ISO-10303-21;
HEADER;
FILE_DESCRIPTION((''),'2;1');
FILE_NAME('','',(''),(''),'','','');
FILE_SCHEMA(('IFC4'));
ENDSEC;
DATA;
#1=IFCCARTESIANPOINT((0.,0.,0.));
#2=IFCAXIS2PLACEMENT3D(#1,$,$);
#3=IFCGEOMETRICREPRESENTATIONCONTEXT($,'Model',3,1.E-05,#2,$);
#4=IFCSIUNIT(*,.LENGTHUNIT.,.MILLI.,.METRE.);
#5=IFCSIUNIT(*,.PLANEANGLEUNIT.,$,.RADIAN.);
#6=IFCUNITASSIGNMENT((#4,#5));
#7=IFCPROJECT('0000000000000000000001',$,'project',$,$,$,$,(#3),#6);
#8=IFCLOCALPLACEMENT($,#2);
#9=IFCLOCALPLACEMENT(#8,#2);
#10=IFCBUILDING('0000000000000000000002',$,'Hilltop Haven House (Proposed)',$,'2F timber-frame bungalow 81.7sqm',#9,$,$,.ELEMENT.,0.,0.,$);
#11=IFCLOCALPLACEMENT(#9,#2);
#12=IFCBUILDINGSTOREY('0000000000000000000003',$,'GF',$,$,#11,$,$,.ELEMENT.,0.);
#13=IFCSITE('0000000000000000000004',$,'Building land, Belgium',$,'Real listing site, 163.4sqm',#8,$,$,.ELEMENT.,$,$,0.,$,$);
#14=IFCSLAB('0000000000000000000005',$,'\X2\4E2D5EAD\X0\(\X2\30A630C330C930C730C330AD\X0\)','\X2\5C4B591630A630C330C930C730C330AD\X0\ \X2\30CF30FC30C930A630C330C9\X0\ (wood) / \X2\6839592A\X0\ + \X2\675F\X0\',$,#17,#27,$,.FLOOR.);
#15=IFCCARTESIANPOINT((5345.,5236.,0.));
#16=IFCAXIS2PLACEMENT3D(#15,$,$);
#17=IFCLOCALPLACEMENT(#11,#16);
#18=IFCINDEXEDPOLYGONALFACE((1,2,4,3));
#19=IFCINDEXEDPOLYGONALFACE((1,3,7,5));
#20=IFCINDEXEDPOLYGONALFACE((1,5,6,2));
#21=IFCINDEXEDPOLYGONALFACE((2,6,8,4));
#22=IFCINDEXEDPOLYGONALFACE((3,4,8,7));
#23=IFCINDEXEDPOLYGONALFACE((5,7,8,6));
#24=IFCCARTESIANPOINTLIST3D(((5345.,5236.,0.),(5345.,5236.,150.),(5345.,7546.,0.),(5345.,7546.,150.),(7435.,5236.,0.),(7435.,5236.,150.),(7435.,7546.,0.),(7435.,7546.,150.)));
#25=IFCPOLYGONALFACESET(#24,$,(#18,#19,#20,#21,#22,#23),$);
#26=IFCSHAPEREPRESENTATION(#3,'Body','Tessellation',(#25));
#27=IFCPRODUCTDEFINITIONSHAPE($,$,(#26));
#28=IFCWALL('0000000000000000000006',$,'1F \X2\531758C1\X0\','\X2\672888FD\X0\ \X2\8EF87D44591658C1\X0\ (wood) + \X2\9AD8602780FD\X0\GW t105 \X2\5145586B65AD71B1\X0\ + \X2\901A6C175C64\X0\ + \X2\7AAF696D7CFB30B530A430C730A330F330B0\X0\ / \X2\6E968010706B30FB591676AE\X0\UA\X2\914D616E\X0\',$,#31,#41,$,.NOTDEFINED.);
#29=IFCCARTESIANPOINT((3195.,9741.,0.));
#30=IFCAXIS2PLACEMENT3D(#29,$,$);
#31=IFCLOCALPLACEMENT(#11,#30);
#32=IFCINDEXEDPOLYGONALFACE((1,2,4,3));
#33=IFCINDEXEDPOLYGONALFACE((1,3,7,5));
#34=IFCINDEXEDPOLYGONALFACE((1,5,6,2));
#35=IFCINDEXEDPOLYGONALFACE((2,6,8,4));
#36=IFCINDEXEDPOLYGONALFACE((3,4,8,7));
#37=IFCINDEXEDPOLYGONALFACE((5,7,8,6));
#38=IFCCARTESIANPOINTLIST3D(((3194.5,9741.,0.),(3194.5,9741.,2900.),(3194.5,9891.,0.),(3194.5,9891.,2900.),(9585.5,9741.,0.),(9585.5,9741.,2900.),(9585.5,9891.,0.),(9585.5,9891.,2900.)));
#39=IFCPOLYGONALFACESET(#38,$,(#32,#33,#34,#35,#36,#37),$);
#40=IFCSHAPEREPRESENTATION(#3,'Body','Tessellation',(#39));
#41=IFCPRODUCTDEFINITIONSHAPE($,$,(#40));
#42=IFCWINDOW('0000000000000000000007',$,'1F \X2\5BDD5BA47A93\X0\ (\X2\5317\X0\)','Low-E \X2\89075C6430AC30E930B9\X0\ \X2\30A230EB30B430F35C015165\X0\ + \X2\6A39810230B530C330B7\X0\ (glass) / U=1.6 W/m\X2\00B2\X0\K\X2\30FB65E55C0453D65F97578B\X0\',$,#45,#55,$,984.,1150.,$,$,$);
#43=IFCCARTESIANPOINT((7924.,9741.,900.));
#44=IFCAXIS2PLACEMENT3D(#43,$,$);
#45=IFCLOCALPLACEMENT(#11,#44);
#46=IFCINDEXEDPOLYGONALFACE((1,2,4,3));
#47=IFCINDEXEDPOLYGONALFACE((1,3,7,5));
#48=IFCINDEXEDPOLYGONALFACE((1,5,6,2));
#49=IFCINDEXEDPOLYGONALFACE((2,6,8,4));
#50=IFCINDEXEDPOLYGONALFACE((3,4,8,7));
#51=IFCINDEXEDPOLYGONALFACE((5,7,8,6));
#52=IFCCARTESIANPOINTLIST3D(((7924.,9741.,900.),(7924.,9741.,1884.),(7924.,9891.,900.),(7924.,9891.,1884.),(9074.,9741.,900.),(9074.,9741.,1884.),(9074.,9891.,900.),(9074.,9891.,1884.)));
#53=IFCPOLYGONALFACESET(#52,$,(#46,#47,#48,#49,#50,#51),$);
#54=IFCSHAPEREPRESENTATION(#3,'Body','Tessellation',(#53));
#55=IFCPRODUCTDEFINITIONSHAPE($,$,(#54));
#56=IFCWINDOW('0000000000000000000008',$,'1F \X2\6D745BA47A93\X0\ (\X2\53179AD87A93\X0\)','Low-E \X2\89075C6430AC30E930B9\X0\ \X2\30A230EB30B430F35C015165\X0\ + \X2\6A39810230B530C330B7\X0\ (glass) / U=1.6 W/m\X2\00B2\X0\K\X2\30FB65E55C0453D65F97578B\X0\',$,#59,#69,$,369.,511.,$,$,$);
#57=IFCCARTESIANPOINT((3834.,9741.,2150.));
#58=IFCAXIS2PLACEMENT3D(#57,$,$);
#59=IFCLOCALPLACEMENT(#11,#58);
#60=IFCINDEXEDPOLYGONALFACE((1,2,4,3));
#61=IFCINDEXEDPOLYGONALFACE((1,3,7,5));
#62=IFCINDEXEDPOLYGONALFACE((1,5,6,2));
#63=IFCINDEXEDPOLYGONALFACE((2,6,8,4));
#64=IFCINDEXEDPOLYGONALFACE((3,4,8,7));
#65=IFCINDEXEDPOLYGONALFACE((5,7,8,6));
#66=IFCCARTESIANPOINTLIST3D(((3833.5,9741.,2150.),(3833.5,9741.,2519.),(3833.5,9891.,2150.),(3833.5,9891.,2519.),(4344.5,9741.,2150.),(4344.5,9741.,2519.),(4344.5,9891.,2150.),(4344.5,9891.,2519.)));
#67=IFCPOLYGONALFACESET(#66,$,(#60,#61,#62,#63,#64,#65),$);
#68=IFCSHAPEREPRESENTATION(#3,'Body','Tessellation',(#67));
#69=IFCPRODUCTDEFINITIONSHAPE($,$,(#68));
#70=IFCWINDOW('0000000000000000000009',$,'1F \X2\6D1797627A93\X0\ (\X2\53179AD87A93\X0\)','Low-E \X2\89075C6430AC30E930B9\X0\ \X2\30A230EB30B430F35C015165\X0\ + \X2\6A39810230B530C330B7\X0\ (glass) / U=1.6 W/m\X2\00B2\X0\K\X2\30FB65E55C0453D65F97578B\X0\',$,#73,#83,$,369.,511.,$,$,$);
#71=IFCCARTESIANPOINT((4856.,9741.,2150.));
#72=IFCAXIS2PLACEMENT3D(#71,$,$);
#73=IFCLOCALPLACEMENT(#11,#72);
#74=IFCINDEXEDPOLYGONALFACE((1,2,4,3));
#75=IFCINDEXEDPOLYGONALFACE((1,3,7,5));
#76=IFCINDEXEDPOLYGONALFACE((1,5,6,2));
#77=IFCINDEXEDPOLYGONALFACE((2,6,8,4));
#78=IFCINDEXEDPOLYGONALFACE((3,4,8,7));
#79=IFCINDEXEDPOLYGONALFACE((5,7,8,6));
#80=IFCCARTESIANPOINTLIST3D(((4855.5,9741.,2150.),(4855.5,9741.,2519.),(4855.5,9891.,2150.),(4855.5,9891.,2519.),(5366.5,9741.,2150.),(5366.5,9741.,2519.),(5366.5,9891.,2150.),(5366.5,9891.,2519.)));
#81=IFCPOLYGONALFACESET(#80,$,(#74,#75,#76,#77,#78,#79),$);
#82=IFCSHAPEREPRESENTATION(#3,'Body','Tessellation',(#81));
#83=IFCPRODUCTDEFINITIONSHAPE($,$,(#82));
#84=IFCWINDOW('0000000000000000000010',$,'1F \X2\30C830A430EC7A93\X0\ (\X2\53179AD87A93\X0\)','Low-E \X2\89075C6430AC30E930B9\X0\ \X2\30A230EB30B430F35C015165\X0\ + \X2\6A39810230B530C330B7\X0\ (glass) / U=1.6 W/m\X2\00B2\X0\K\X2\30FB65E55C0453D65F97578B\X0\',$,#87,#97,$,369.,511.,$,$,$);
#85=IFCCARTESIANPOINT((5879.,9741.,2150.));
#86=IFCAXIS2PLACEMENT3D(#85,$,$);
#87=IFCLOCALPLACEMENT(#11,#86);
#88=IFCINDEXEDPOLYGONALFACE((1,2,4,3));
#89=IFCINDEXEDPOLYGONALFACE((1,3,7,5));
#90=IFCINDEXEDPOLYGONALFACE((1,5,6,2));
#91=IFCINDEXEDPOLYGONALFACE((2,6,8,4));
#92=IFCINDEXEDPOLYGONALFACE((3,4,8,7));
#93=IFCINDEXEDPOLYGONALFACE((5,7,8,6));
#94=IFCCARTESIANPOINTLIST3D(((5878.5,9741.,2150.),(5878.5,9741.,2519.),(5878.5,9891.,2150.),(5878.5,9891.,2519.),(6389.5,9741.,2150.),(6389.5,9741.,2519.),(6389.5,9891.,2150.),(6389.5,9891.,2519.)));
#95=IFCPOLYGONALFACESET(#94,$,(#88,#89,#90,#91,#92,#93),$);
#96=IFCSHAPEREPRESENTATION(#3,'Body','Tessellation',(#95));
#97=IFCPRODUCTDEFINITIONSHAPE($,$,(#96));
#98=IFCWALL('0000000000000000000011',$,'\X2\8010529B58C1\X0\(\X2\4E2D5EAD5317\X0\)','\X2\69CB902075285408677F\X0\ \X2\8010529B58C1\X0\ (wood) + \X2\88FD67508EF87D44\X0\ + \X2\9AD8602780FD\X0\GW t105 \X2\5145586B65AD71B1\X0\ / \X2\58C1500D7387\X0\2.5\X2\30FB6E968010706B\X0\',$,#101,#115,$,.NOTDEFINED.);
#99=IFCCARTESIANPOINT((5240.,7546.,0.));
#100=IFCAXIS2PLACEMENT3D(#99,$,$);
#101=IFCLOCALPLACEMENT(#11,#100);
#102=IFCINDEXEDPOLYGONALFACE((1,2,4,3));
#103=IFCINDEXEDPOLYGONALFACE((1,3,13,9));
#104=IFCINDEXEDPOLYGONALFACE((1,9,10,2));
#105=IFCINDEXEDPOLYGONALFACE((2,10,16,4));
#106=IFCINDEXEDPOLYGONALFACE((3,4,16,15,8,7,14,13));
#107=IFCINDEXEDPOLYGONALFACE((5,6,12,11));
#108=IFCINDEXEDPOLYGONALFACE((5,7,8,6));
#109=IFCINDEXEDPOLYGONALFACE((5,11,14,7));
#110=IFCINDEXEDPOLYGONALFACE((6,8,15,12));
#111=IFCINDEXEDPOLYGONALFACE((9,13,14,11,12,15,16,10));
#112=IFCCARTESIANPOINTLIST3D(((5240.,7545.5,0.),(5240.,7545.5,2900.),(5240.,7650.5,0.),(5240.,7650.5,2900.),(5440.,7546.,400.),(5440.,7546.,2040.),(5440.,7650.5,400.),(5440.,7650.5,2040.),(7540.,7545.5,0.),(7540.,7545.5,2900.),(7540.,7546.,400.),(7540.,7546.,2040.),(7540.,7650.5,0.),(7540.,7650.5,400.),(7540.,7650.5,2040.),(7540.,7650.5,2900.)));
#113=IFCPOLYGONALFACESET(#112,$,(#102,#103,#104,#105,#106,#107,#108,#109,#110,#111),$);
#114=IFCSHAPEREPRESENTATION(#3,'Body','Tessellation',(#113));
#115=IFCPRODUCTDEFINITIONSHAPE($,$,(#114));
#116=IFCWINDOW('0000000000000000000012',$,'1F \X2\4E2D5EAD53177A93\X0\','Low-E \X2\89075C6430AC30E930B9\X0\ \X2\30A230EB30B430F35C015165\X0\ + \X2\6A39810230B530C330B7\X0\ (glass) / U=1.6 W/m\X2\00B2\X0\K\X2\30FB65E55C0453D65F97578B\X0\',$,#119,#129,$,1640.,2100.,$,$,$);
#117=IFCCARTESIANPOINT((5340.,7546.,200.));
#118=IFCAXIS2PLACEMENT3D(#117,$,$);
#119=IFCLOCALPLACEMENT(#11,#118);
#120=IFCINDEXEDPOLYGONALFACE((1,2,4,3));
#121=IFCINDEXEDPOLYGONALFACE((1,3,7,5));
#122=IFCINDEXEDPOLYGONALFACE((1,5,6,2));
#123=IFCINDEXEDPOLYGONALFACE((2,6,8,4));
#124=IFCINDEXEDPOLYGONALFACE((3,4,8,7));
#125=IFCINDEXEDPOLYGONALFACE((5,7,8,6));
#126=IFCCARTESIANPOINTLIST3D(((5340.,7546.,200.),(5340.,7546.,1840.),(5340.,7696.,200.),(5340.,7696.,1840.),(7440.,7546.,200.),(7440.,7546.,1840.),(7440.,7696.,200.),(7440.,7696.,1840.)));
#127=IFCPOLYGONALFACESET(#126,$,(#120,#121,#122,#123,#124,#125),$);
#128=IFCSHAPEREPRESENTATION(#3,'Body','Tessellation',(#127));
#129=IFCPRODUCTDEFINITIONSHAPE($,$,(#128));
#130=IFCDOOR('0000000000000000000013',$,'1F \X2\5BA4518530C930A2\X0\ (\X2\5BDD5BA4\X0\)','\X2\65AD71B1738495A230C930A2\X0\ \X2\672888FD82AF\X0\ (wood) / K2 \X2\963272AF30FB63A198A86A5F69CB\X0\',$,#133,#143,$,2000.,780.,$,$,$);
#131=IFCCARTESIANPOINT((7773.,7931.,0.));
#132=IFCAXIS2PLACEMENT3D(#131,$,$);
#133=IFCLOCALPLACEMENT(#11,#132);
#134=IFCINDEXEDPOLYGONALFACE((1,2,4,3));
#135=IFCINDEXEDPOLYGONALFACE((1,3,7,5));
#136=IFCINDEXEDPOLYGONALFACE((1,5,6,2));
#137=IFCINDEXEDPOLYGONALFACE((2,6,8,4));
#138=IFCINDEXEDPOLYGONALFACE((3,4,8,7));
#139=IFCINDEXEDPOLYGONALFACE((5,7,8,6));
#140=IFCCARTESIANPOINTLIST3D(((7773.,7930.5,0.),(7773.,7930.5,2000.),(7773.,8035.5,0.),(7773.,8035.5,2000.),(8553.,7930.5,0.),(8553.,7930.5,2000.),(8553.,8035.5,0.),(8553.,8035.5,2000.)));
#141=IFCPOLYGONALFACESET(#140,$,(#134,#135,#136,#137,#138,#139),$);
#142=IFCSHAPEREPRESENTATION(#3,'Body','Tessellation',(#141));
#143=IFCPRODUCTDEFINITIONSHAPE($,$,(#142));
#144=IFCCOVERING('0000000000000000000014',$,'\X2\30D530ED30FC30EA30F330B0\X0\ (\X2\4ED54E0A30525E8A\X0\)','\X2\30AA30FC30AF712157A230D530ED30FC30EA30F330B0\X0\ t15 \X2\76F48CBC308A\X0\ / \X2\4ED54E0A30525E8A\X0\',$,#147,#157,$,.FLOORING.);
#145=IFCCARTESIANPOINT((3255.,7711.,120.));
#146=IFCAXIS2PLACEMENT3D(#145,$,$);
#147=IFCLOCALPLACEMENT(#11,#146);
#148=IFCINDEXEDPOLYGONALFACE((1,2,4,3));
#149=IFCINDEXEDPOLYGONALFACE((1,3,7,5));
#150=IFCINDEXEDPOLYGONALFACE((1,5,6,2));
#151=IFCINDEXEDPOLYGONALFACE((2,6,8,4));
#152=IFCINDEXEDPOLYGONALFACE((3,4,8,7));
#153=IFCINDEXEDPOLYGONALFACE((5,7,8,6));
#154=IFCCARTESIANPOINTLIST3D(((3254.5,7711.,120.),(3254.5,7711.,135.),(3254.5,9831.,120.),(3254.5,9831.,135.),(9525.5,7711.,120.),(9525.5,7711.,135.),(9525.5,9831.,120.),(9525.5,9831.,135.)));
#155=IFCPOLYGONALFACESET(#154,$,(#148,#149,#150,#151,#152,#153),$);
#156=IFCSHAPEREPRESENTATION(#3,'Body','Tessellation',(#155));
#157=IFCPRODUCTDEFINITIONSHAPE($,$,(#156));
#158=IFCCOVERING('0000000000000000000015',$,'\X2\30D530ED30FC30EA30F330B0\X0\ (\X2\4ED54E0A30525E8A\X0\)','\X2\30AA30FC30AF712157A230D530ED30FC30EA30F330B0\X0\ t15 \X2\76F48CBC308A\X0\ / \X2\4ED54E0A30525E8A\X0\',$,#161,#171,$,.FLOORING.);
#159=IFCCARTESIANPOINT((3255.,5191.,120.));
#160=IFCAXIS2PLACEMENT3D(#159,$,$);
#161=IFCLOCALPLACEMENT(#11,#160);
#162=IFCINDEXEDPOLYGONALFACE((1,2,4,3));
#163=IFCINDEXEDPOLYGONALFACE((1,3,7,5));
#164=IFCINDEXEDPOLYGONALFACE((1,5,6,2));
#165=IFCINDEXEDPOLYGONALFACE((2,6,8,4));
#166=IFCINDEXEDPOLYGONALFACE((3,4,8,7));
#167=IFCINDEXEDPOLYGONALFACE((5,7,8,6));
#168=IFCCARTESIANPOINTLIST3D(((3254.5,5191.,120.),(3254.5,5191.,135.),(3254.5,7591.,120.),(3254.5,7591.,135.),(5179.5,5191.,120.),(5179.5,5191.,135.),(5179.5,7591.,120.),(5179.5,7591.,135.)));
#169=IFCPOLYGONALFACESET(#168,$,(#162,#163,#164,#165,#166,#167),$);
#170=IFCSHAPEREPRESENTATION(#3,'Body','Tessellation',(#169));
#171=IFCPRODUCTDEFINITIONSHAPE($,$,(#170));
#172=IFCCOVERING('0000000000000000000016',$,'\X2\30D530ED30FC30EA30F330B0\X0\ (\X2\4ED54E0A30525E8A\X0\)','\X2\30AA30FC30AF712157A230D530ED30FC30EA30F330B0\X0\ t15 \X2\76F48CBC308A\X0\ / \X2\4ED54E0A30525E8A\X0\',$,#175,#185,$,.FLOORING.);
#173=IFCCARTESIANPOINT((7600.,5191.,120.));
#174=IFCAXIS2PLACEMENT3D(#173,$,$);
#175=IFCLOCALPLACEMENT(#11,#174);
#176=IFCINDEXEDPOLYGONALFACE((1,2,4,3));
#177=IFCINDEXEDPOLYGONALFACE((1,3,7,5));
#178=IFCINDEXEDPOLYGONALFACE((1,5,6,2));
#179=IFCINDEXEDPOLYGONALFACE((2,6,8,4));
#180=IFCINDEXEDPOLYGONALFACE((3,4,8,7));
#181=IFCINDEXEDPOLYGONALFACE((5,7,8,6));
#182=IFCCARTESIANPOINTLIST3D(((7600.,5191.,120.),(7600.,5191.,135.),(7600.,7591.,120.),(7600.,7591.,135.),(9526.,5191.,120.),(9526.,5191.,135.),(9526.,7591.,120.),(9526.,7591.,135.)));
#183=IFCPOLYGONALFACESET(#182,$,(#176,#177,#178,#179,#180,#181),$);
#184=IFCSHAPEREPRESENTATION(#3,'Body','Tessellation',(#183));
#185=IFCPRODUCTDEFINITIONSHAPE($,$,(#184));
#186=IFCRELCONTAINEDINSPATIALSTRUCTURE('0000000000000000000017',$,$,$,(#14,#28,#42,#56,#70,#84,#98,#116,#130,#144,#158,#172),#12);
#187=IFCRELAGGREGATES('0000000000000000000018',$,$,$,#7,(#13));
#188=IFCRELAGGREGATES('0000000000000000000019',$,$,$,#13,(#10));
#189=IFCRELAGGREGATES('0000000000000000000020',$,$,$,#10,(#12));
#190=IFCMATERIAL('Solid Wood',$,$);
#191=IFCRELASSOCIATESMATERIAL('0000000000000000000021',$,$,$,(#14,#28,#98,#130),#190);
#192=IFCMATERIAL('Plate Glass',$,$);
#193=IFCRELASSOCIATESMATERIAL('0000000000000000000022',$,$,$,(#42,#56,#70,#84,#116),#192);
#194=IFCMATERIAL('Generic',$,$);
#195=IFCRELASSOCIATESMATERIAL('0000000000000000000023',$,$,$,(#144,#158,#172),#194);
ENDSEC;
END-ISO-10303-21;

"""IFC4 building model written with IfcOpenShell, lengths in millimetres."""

from ifc_helpers import new_model, si_unit, frame, frame_2d, origin, place, context, project, spatial, rectangle, extrude, material, element, fill, save


model = new_model("IFC4")

# Units and contexts
model_context = context("Model", 3, precision=1e-05, world=origin())
ifc_project = project(units=[si_unit("LENGTHUNIT", "METRE", prefix="MILLI"), si_unit("PLANEANGLEUNIT", "RADIAN")], contexts=[model_context])

# Site, building, storey
site_placement = place(None, origin())
site = spatial("IfcSite", under=ifc_project, at=site_placement, Name="Building land, Belgium", ObjectType="Real listing site, 163.4sqm", CompositionType="ELEMENT", RefElevation=0.0)
building_placement = place(site_placement, origin())
building = spatial("IfcBuilding", under=site, at=building_placement, Name="Hilltop Haven House (Proposed)", ObjectType="2F timber-frame bungalow 81.7sqm", CompositionType="ELEMENT", ElevationOfRefHeight=0.0, ElevationOfTerrain=0.0)
storey_placement = place(building_placement, origin())
storey = spatial("IfcBuildingStorey", under=building, at=storey_placement, Name="GF", CompositionType="ELEMENT", Elevation=0.0)

# Slab
ifc_material_1 = material(Name="Solid Wood")
slab_1_placement = place(storey_placement, frame((5345.0, 5236.0, 0.0)))
element("IfcSlab", 1, at=slab_1_placement, inside=storey, material=ifc_material_1, Name="中庭(ウッドデッキ)", Description="屋外ウッドデッキ ハードウッド (wood) / 根太 + 束", PredefinedType="FLOOR", context=model_context, shape_type="SweptSolid", body=[
    extrude(rectangle(XDim=2090.0, YDim=2310.0, at=frame_2d((1045.0, 1155.0))), frame((5345.0, 5236.0, 0.0)), (0.0, 0.0, 1.0), 150.0),
])

# Wall, openings, windows
wall_1_placement = place(storey_placement, frame((3195.0, 9741.0, 0.0)))
wall_1 = element("IfcWall", 2, at=wall_1_placement, inside=storey, material=ifc_material_1, Name="1F 北壁", Description="木製 軸組外壁 (wood) + 高性能GW t105 充填断熱 + 通気層 + 窯業系サイディング / 準耐火・外皮UA配慮", PredefinedType="NOTDEFINED", context=model_context, shape_type="SweptSolid", body=[
    extrude(rectangle(XDim=6391.0, YDim=150.0, at=frame_2d((3195.0, 75.0))), frame((3195.0, 9741.0, 0.0)), (0.0, 0.0, 1.0), 2900.0),
])
opening_1_placement = place(storey_placement, frame((7924.0, 9741.0, 900.0)))
opening_1 = element("IfcOpeningElement", 3, at=opening_1_placement, cuts=wall_1, PredefinedType="NOTDEFINED", context=model_context, shape_type="SweptSolid", body=[
    extrude(rectangle(XDim=1150.0, YDim=150.0, at=frame_2d((575.0, 75.0))), frame((7924.0, 9741.0, 900.0)), (0.0, 0.0, 1.0), 984.0),
])
opening_2_placement = place(storey_placement, frame((3834.0, 9741.0, 2150.0)))
opening_2 = element("IfcOpeningElement", 4, at=opening_2_placement, cuts=wall_1, PredefinedType="NOTDEFINED", context=model_context, shape_type="SweptSolid", body=[
    extrude(rectangle(XDim=511.0, YDim=150.0, at=frame_2d((255.0, 75.0))), frame((3834.0, 9741.0, 2150.0)), (0.0, 0.0, 1.0), 369.0),
])
opening_3_placement = place(storey_placement, frame((4856.0, 9741.0, 2150.0)))
opening_3 = element("IfcOpeningElement", 5, at=opening_3_placement, cuts=wall_1, PredefinedType="NOTDEFINED", context=model_context, shape_type="SweptSolid", body=[
    extrude(rectangle(XDim=511.0, YDim=150.0, at=frame_2d((255.0, 75.0))), frame((4856.0, 9741.0, 2150.0)), (0.0, 0.0, 1.0), 369.0),
])
opening_4_placement = place(storey_placement, frame((5879.0, 9741.0, 2150.0)))
opening_4 = element("IfcOpeningElement", 6, at=opening_4_placement, cuts=wall_1, PredefinedType="NOTDEFINED", context=model_context, shape_type="SweptSolid", body=[
    extrude(rectangle(XDim=511.0, YDim=150.0, at=frame_2d((255.0, 75.0))), frame((5879.0, 9741.0, 2150.0)), (0.0, 0.0, 1.0), 369.0),
])
ifc_material_2 = material(Name="Plate Glass")
window_1_placement = place(storey_placement, frame((7924.0, 9741.0, 900.0)))
window_1 = element("IfcWindow", 7, at=window_1_placement, inside=storey, material=ifc_material_2, Name="1F 寝室窓 (北)", Description="Low-E 複層ガラス アルゴン封入 + 樹脂サッシ (glass) / U=1.6 W/m²K・日射取得型", OverallHeight=984.0, OverallWidth=1150.0, context=model_context, shape_type="SweptSolid", body=[
    extrude(rectangle(XDim=1150.0, YDim=150.0, at=frame_2d((575.0, 75.0))), frame((7924.0, 9741.0, 900.0)), (0.0, 0.0, 1.0), 984.0),
])
fill(opening_1, window_1)
window_2_placement = place(storey_placement, frame((3834.0, 9741.0, 2150.0)))
window_2 = element("IfcWindow", 8, at=window_2_placement, inside=storey, material=ifc_material_2, Name="1F 浴室窓 (北高窓)", Description="Low-E 複層ガラス アルゴン封入 + 樹脂サッシ (glass) / U=1.6 W/m²K・日射取得型", OverallHeight=369.0, OverallWidth=511.0, context=model_context, shape_type="SweptSolid", body=[
    extrude(rectangle(XDim=511.0, YDim=150.0, at=frame_2d((255.0, 75.0))), frame((3834.0, 9741.0, 2150.0)), (0.0, 0.0, 1.0), 369.0),
])
fill(opening_2, window_2)
window_3_placement = place(storey_placement, frame((4856.0, 9741.0, 2150.0)))
window_3 = element("IfcWindow", 9, at=window_3_placement, inside=storey, material=ifc_material_2, Name="1F 洗面窓 (北高窓)", Description="Low-E 複層ガラス アルゴン封入 + 樹脂サッシ (glass) / U=1.6 W/m²K・日射取得型", OverallHeight=369.0, OverallWidth=511.0, context=model_context, shape_type="SweptSolid", body=[
    extrude(rectangle(XDim=511.0, YDim=150.0, at=frame_2d((255.0, 75.0))), frame((4856.0, 9741.0, 2150.0)), (0.0, 0.0, 1.0), 369.0),
])
fill(opening_3, window_3)
window_4_placement = place(storey_placement, frame((5879.0, 9741.0, 2150.0)))
window_4 = element("IfcWindow", 10, at=window_4_placement, inside=storey, material=ifc_material_2, Name="1F トイレ窓 (北高窓)", Description="Low-E 複層ガラス アルゴン封入 + 樹脂サッシ (glass) / U=1.6 W/m²K・日射取得型", OverallHeight=369.0, OverallWidth=511.0, context=model_context, shape_type="SweptSolid", body=[
    extrude(rectangle(XDim=511.0, YDim=150.0, at=frame_2d((255.0, 75.0))), frame((5879.0, 9741.0, 2150.0)), (0.0, 0.0, 1.0), 369.0),
])
fill(opening_4, window_4)

# Wall, opening, window
wall_2_placement = place(storey_placement, frame((5240.0, 7546.0, 0.0)))
wall_2 = element("IfcWall", 11, at=wall_2_placement, inside=storey, material=ifc_material_1, Name="耐力壁(中庭北)", Description="構造用合板 耐力壁 (wood) + 製材軸組 + 高性能GW t105 充填断熱 / 壁倍率2.5・準耐火", PredefinedType="NOTDEFINED", context=model_context, shape_type="SweptSolid", body=[
    extrude(rectangle(XDim=2300.0, YDim=105.0, at=frame_2d((1150.0, 52.0))), frame((5240.0, 7546.0, 0.0)), (0.0, 0.0, 1.0), 2900.0),
])
opening_5_placement = place(storey_placement, frame((5340.0, 7546.0, 200.0)))
opening_5 = element("IfcOpeningElement", 12, at=opening_5_placement, cuts=wall_2, PredefinedType="NOTDEFINED", context=model_context, shape_type="SweptSolid", body=[
    extrude(rectangle(XDim=2100.0, YDim=150.0, at=frame_2d((1050.0, 75.0))), frame((5340.0, 7546.0, 200.0)), (0.0, 0.0, 1.0), 1640.0),
])
window_5_placement = place(storey_placement, frame((5340.0, 7546.0, 200.0)))
window_5 = element("IfcWindow", 13, at=window_5_placement, inside=storey, material=ifc_material_2, Name="1F 中庭北窓", Description="Low-E 複層ガラス アルゴン封入 + 樹脂サッシ (glass) / U=1.6 W/m²K・日射取得型", OverallHeight=1640.0, OverallWidth=2100.0, context=model_context, shape_type="SweptSolid", body=[
    extrude(rectangle(XDim=2100.0, YDim=150.0, at=frame_2d((1050.0, 75.0))), frame((5340.0, 7546.0, 200.0)), (0.0, 0.0, 1.0), 1640.0),
])
fill(opening_5, window_5)

# Door
door_1_placement = place(storey_placement, frame((7773.0, 7931.0, 0.0)))
element("IfcDoor", 14, at=door_1_placement, inside=storey, material=ifc_material_1, Name="1F 室内ドア (寝室)", Description="断熱玄関ドア 木製芯 (wood) / K2 防犯・採風機構", OverallHeight=2000.0, OverallWidth=780.0, context=model_context, shape_type="SweptSolid", body=[
    extrude(rectangle(XDim=780.0, YDim=105.0, at=frame_2d((390.0, 52.0))), frame((7773.0, 7931.0, 0.0)), (0.0, 0.0, 1.0), 2000.0),
])

# Coverings
ifc_material_3 = material(Name="Generic")
covering_1_placement = place(storey_placement, frame((3255.0, 7711.0, 120.0)))
element("IfcCovering", 15, at=covering_1_placement, inside=storey, material=ifc_material_3, Name="フローリング (仕上げ床)", Description="オーク無垢フローリング t15 直貼り / 仕上げ床", PredefinedType="FLOORING", context=model_context, shape_type="SweptSolid", body=[
    extrude(rectangle(XDim=6271.0, YDim=2120.0, at=frame_2d((3135.0, 1060.0))), frame((3255.0, 7711.0, 120.0)), (0.0, 0.0, 1.0), 15.0),
])
covering_2_placement = place(storey_placement, frame((3255.0, 5191.0, 120.0)))
element("IfcCovering", 16, at=covering_2_placement, inside=storey, material=ifc_material_3, Name="フローリング (仕上げ床)", Description="オーク無垢フローリング t15 直貼り / 仕上げ床", PredefinedType="FLOORING", context=model_context, shape_type="SweptSolid", body=[
    extrude(rectangle(XDim=1925.0, YDim=2400.0, at=frame_2d((962.0, 1200.0))), frame((3255.0, 5191.0, 120.0)), (0.0, 0.0, 1.0), 15.0),
])
covering_3_placement = place(storey_placement, frame((7600.0, 5191.0, 120.0)))
element("IfcCovering", 17, at=covering_3_placement, inside=storey, material=ifc_material_3, Name="フローリング (仕上げ床)", Description="オーク無垢フローリング t15 直貼り / 仕上げ床", PredefinedType="FLOORING", context=model_context, shape_type="SweptSolid", body=[
    extrude(rectangle(XDim=1926.0, YDim=2400.0, at=frame_2d((963.0, 1200.0))), frame((7600.0, 5191.0, 120.0)), (0.0, 0.0, 1.0), 15.0),
])

save(model, "model.ifc")
